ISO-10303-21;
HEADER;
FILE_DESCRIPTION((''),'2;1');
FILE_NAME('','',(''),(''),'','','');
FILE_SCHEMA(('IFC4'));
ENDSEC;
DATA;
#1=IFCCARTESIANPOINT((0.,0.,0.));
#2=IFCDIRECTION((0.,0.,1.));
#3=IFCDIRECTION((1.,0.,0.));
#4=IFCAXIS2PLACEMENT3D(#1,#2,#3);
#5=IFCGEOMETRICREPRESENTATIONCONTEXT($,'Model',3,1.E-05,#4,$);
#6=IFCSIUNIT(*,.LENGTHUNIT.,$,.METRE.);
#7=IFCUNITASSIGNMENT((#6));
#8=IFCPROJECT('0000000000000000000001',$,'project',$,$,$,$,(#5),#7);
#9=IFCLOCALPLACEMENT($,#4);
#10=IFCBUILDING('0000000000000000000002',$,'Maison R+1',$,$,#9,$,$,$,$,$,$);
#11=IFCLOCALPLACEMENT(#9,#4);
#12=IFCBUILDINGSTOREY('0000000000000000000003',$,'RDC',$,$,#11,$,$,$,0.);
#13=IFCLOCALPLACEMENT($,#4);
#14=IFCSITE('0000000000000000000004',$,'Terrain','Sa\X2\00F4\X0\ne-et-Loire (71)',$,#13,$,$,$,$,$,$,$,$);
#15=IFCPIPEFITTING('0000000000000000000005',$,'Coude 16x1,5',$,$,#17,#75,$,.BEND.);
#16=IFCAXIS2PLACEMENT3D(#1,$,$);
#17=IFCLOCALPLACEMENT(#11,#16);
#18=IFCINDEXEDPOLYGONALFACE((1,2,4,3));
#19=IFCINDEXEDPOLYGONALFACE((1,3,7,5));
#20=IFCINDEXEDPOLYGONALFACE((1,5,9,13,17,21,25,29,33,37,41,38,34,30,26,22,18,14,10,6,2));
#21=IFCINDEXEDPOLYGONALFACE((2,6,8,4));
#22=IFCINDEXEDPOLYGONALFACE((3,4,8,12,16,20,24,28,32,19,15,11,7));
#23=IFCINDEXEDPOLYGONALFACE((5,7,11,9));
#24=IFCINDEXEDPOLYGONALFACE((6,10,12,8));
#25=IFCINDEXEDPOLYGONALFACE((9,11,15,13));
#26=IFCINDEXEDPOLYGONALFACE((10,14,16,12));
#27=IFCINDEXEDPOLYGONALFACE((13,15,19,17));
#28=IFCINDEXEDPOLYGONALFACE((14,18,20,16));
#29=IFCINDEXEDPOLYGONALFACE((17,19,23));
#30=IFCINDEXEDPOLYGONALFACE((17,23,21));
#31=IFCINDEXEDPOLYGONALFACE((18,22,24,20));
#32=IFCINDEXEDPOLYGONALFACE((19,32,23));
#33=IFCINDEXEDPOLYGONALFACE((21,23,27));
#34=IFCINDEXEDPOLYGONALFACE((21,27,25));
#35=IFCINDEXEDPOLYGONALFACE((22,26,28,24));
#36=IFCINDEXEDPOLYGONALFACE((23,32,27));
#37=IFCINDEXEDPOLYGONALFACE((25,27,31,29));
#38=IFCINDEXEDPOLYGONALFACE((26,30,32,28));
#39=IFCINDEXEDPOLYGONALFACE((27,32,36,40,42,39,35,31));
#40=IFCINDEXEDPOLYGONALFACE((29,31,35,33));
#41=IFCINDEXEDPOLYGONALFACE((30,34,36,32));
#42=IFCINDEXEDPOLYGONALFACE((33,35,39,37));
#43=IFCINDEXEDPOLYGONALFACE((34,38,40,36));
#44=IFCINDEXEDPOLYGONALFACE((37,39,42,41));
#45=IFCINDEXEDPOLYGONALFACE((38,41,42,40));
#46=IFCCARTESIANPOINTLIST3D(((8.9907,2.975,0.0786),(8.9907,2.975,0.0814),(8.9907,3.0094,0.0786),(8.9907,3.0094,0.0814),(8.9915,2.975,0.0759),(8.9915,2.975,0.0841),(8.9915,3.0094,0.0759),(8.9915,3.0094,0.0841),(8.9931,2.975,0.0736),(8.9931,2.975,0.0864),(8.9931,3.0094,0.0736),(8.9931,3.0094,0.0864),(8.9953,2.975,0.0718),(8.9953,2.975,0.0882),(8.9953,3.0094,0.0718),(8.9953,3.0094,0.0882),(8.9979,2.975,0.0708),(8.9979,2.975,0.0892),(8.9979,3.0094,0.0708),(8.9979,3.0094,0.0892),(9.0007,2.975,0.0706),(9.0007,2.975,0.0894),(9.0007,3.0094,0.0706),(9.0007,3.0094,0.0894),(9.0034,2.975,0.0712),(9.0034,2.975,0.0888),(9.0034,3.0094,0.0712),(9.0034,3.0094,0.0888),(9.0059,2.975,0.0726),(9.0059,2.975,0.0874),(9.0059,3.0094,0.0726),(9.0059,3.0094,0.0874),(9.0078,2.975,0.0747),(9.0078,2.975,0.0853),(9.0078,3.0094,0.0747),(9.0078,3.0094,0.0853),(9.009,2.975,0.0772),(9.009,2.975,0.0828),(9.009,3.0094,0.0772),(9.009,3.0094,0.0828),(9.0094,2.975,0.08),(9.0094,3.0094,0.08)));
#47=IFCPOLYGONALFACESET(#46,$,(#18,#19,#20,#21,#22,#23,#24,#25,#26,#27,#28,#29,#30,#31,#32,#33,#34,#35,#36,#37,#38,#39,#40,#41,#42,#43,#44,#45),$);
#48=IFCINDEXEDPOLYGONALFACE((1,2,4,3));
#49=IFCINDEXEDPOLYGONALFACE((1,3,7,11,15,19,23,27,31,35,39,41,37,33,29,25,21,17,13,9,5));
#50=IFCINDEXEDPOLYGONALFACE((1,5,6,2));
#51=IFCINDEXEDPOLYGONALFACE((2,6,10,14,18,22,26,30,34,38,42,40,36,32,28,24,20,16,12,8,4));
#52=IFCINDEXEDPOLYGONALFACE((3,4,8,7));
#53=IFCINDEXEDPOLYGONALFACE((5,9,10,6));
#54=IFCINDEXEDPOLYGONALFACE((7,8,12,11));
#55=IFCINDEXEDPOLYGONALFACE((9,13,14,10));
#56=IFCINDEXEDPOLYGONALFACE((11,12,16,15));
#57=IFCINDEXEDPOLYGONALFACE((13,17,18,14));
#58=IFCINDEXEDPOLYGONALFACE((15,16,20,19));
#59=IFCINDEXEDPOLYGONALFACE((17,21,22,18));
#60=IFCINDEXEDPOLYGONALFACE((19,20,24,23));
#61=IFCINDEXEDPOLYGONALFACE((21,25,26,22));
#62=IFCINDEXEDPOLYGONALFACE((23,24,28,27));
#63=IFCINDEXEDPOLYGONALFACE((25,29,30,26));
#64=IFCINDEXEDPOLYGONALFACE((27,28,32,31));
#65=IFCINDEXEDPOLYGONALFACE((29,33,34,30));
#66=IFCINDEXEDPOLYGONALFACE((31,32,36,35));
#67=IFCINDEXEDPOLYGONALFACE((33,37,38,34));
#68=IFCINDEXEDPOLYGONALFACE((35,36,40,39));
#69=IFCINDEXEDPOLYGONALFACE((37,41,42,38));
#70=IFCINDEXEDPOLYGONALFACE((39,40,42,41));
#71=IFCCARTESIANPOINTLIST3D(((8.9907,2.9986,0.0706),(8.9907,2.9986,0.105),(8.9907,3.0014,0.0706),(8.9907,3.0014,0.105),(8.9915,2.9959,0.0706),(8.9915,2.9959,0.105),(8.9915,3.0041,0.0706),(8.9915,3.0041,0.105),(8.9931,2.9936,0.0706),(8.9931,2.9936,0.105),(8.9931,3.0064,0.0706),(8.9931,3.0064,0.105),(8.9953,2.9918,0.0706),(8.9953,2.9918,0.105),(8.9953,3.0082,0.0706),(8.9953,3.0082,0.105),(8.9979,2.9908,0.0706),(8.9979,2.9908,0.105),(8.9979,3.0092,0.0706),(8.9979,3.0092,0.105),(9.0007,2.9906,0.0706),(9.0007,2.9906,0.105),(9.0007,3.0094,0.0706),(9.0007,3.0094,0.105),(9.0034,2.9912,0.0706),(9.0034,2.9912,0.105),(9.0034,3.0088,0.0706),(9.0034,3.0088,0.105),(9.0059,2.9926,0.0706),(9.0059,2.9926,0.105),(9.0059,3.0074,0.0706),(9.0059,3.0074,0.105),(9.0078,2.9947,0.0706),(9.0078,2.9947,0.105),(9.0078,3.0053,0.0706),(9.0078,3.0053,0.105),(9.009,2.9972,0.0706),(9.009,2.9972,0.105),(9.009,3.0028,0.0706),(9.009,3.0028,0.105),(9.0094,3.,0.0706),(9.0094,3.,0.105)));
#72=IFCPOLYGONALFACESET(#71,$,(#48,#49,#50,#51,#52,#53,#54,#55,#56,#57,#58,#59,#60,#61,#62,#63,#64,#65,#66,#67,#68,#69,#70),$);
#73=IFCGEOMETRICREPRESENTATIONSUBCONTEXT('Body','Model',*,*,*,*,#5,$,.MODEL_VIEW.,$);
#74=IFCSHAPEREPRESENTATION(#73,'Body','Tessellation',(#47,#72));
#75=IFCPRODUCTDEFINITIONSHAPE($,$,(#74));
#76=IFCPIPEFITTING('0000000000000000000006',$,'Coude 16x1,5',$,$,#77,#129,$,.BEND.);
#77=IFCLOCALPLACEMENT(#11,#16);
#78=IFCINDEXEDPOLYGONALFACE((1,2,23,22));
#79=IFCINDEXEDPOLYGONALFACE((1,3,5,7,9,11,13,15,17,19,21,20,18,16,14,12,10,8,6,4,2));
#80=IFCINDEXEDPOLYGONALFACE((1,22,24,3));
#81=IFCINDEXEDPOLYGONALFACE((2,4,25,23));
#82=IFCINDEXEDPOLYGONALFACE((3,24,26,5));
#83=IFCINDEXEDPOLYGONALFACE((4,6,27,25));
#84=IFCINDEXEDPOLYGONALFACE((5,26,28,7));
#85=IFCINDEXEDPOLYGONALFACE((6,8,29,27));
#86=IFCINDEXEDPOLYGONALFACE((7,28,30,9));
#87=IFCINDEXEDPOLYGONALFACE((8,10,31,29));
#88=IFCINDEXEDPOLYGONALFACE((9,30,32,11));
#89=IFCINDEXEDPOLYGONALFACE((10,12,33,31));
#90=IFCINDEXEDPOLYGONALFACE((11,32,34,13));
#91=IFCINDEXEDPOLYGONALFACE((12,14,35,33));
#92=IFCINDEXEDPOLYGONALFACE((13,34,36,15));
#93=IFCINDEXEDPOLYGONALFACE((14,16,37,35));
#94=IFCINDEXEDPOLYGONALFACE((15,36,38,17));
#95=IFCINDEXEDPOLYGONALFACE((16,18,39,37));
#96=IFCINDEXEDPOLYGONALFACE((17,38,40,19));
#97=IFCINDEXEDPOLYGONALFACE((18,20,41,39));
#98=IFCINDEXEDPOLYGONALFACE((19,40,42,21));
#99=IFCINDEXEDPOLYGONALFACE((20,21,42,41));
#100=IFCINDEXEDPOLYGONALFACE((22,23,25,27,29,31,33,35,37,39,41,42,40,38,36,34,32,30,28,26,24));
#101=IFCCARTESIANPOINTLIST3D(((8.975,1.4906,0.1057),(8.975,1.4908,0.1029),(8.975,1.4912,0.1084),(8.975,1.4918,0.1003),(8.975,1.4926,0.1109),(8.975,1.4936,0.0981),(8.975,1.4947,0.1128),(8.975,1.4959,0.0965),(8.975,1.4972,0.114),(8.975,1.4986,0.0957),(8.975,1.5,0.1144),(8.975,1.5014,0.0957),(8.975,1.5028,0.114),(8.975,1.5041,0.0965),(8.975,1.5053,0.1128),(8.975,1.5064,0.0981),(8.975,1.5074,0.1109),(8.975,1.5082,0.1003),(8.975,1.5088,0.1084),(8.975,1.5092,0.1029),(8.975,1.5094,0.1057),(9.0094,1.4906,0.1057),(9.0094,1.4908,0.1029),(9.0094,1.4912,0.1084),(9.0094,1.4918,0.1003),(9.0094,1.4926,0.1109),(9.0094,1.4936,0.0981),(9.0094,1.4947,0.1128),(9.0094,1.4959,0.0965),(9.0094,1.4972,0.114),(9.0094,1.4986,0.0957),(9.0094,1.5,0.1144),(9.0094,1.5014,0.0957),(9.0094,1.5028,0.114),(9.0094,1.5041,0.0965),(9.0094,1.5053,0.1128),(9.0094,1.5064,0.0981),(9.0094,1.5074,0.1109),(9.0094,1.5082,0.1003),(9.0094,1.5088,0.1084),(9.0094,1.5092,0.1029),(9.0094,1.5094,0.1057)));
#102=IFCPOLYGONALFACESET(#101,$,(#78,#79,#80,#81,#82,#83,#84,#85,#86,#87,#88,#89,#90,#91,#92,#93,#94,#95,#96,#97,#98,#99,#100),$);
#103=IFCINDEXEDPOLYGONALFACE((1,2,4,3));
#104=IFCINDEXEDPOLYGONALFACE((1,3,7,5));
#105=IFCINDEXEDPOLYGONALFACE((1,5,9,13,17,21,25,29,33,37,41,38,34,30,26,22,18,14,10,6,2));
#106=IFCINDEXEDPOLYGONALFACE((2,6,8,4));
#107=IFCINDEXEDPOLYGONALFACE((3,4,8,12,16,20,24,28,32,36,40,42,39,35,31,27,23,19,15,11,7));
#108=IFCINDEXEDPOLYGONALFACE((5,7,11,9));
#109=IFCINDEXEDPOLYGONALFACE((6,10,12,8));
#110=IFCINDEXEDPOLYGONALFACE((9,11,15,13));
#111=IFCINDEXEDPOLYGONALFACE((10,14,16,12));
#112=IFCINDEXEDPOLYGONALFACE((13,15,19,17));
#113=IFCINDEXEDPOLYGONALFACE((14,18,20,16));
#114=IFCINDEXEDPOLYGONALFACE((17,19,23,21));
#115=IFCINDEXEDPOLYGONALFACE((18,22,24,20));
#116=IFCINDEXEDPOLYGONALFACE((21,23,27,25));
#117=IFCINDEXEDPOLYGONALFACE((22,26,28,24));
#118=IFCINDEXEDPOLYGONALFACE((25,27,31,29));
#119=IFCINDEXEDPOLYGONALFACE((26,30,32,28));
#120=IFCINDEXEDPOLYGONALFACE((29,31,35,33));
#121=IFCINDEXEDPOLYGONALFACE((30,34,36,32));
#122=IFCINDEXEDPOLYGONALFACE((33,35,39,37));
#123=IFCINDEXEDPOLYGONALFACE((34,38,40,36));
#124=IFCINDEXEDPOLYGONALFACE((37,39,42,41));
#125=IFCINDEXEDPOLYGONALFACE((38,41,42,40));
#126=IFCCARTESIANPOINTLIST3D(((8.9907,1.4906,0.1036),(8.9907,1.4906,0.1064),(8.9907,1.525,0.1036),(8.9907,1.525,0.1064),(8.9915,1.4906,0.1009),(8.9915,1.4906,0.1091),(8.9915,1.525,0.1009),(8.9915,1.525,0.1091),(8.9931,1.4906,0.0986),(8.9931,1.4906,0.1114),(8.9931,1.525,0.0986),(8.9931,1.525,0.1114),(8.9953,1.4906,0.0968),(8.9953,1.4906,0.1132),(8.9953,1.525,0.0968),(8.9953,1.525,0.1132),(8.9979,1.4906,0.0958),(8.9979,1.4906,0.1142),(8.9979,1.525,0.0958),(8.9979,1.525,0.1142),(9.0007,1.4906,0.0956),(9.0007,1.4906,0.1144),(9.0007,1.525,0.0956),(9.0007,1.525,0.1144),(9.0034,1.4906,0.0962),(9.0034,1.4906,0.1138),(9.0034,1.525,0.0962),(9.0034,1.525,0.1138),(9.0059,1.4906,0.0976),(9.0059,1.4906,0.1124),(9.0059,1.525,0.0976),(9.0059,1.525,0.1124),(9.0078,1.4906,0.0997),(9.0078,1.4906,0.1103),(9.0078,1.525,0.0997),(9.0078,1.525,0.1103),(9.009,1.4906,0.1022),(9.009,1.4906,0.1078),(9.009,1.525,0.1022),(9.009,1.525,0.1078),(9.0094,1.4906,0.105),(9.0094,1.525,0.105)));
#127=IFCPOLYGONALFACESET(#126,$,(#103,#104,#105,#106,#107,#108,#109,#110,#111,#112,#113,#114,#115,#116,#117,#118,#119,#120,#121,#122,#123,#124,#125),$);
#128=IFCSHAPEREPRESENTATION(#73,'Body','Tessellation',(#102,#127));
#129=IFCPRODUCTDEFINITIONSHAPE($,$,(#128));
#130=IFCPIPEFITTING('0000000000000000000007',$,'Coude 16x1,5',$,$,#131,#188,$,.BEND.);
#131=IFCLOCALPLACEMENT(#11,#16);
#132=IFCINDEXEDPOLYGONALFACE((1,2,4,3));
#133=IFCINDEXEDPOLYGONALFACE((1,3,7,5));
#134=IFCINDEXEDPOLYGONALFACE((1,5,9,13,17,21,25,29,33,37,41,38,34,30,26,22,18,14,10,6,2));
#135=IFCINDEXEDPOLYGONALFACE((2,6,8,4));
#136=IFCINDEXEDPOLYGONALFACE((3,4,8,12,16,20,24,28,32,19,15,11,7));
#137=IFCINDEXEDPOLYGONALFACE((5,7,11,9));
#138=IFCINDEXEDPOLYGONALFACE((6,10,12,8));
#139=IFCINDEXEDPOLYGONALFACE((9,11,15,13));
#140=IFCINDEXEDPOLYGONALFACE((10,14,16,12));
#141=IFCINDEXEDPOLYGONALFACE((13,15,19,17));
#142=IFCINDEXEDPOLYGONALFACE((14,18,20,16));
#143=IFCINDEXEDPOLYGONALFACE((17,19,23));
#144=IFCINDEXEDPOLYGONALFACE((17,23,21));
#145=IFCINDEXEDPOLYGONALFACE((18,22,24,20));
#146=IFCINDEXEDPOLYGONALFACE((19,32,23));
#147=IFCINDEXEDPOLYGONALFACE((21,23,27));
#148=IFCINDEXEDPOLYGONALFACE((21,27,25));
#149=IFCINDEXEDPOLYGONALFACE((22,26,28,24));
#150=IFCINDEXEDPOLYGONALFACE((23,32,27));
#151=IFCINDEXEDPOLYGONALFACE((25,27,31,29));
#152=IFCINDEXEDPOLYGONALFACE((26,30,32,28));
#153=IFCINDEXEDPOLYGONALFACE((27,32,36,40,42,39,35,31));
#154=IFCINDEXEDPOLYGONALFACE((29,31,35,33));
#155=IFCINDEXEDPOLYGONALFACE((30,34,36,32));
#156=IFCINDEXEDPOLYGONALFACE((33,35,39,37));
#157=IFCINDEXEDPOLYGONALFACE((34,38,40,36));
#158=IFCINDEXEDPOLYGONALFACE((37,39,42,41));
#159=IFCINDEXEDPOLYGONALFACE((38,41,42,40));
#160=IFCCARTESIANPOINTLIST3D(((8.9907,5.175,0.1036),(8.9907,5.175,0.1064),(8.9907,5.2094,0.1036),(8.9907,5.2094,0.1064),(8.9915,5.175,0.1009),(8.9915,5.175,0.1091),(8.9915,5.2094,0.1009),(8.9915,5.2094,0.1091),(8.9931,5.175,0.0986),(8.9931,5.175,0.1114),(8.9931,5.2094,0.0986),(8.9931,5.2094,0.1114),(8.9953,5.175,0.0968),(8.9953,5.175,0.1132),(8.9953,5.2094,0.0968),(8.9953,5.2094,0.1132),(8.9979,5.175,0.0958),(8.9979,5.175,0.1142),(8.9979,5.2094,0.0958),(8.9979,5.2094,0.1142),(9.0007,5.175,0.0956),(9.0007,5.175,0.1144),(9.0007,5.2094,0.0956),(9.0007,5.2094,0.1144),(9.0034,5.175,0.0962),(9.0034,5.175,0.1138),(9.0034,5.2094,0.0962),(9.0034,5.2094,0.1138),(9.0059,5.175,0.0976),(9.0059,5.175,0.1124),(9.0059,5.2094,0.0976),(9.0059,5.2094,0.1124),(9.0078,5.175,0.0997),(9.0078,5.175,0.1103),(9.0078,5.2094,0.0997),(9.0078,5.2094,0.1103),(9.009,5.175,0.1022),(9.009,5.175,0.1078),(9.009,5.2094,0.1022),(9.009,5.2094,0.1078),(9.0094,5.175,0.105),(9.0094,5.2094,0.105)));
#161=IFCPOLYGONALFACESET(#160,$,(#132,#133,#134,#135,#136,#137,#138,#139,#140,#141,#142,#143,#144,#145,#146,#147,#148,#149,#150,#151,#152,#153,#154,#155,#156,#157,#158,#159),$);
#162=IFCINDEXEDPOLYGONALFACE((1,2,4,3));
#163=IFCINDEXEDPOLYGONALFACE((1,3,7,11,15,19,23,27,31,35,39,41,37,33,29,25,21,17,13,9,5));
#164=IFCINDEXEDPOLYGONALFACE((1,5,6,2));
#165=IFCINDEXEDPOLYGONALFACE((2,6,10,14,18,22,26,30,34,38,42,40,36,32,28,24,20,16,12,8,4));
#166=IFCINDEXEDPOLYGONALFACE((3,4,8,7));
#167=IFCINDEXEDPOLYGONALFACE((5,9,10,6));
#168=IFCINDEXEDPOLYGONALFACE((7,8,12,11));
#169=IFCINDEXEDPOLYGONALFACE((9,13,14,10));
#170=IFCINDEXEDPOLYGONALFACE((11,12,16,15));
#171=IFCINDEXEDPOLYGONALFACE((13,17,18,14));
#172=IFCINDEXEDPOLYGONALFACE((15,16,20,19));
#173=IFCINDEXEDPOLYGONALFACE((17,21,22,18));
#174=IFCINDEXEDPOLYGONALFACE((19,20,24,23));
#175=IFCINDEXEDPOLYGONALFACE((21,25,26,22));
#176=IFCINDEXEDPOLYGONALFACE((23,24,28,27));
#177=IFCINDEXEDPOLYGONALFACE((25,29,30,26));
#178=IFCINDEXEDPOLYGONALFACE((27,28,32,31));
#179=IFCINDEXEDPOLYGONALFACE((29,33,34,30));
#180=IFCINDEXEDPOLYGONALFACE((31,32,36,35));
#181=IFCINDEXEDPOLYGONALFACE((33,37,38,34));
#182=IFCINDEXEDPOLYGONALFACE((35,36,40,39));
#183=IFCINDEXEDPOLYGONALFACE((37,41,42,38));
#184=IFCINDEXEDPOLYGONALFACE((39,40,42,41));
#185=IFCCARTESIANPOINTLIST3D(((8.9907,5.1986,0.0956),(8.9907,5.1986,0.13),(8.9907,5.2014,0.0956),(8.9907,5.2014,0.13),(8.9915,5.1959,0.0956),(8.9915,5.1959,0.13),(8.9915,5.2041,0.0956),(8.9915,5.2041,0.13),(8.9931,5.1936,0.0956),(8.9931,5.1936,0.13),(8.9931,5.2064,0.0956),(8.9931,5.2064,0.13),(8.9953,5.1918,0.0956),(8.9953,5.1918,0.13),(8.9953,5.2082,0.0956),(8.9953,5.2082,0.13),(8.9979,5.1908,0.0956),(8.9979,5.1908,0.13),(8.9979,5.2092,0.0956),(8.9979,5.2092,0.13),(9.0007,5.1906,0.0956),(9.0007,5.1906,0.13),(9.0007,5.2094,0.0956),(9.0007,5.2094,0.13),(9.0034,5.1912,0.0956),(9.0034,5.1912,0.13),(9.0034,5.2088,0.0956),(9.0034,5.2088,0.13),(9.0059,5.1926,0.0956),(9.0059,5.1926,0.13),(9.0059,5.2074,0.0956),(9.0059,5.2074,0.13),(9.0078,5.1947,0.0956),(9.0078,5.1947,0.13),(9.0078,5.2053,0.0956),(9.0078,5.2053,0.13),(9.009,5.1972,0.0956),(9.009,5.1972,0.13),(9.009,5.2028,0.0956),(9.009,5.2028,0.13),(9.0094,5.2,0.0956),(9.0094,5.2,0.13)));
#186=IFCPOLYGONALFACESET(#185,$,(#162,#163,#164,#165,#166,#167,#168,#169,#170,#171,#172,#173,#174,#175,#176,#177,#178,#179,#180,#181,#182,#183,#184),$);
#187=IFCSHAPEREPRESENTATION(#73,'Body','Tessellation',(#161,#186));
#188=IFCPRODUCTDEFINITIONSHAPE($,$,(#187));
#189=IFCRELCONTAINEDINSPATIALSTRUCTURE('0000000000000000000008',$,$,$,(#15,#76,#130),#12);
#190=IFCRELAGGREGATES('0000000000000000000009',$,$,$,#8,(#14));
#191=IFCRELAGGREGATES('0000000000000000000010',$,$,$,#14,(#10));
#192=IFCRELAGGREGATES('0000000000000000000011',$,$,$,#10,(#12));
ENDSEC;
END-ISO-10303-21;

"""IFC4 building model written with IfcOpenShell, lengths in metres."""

from ifc_helpers import new_model, si_unit, frame, origin_with_axes, place, context, subcontext, project, spatial, circle, extrude, element, save


model = new_model("IFC4")

# Units and contexts
model_context = context("Model", 3, precision=1e-05, world=origin_with_axes())
body_context = subcontext(model_context, "Body", "Model", "MODEL_VIEW")
ifc_project = project(units=[si_unit("LENGTHUNIT", "METRE")], contexts=[model_context])

# Site, building, storey
site_placement = place(None, origin_with_axes())
site = spatial("IfcSite", under=ifc_project, at=site_placement, Name="Terrain", Description="Saône-et-Loire (71)")
building_placement = place(None, origin_with_axes())
building = spatial("IfcBuilding", under=site, at=building_placement, Name="Maison R+1")
storey_placement = place(building_placement, origin_with_axes())
storey = spatial("IfcBuildingStorey", under=building, at=storey_placement, Name="RDC", Elevation=0.0)

# Pipe fittings
pipe_fitting_1_placement = place(storey_placement, frame((9.0, 3.0, 0.08), z_axis=(0.0, 0.0, 1.0), x_axis=(1.0, 0.0, 0.0)))
element("IfcPipeFitting", 1, at=pipe_fitting_1_placement, inside=storey, Name="Coude 16x1,5", PredefinedType="BEND", context=body_context, shape_type="SweptSolid", body=[
    extrude(circle(Radius=0.0094), frame((0.0, 0.0094, 0.0), z_axis=(0.0, -1.0, 0.0), x_axis=(1.0, 0.0, 0.0)), (0.0, 0.0, 1.0), 0.0344),
    extrude(circle(Radius=0.0094), frame((0.0, 0.0, -0.0094), z_axis=(0.0, 0.0, 1.0), x_axis=(1.0, 0.0, 0.0)), (0.0, 0.0, 1.0), 0.0344),
])
pipe_fitting_2_placement = place(storey_placement, frame((9.0, 1.5, 0.105), z_axis=(0.0, 0.0, 1.0), x_axis=(1.0, 0.0, 0.0)))
element("IfcPipeFitting", 2, at=pipe_fitting_2_placement, inside=storey, Name="Coude 16x1,5", PredefinedType="BEND", context=body_context, shape_type="SweptSolid", body=[
    extrude(circle(Radius=0.0094), frame((0.0094, 0.0, 0.0), z_axis=(-1.0, 0.0, 0.0), x_axis=(0.0, 0.0, 1.0)), (0.0, 0.0, 1.0), 0.0344),
    extrude(circle(Radius=0.0094), frame((0.0, -0.0094, 0.0), z_axis=(0.0, 1.0, 0.0), x_axis=(1.0, 0.0, 0.0)), (0.0, 0.0, 1.0), 0.0344),
])
pipe_fitting_3_placement = place(storey_placement, frame((9.0, 5.2, 0.105), z_axis=(0.0, 0.0, 1.0), x_axis=(1.0, 0.0, 0.0)))
element("IfcPipeFitting", 3, at=pipe_fitting_3_placement, inside=storey, Name="Coude 16x1,5", PredefinedType="BEND", context=body_context, shape_type="SweptSolid", body=[
    extrude(circle(Radius=0.0094), frame((0.0, 0.0094, 0.0), z_axis=(0.0, -1.0, 0.0), x_axis=(1.0, 0.0, 0.0)), (0.0, 0.0, 1.0), 0.0344),
    extrude(circle(Radius=0.0094), frame((0.0, 0.0, -0.0094), z_axis=(0.0, 0.0, 1.0), x_axis=(1.0, 0.0, 0.0)), (0.0, 0.0, 1.0), 0.0344),
])

save(model, "model.ifc")
